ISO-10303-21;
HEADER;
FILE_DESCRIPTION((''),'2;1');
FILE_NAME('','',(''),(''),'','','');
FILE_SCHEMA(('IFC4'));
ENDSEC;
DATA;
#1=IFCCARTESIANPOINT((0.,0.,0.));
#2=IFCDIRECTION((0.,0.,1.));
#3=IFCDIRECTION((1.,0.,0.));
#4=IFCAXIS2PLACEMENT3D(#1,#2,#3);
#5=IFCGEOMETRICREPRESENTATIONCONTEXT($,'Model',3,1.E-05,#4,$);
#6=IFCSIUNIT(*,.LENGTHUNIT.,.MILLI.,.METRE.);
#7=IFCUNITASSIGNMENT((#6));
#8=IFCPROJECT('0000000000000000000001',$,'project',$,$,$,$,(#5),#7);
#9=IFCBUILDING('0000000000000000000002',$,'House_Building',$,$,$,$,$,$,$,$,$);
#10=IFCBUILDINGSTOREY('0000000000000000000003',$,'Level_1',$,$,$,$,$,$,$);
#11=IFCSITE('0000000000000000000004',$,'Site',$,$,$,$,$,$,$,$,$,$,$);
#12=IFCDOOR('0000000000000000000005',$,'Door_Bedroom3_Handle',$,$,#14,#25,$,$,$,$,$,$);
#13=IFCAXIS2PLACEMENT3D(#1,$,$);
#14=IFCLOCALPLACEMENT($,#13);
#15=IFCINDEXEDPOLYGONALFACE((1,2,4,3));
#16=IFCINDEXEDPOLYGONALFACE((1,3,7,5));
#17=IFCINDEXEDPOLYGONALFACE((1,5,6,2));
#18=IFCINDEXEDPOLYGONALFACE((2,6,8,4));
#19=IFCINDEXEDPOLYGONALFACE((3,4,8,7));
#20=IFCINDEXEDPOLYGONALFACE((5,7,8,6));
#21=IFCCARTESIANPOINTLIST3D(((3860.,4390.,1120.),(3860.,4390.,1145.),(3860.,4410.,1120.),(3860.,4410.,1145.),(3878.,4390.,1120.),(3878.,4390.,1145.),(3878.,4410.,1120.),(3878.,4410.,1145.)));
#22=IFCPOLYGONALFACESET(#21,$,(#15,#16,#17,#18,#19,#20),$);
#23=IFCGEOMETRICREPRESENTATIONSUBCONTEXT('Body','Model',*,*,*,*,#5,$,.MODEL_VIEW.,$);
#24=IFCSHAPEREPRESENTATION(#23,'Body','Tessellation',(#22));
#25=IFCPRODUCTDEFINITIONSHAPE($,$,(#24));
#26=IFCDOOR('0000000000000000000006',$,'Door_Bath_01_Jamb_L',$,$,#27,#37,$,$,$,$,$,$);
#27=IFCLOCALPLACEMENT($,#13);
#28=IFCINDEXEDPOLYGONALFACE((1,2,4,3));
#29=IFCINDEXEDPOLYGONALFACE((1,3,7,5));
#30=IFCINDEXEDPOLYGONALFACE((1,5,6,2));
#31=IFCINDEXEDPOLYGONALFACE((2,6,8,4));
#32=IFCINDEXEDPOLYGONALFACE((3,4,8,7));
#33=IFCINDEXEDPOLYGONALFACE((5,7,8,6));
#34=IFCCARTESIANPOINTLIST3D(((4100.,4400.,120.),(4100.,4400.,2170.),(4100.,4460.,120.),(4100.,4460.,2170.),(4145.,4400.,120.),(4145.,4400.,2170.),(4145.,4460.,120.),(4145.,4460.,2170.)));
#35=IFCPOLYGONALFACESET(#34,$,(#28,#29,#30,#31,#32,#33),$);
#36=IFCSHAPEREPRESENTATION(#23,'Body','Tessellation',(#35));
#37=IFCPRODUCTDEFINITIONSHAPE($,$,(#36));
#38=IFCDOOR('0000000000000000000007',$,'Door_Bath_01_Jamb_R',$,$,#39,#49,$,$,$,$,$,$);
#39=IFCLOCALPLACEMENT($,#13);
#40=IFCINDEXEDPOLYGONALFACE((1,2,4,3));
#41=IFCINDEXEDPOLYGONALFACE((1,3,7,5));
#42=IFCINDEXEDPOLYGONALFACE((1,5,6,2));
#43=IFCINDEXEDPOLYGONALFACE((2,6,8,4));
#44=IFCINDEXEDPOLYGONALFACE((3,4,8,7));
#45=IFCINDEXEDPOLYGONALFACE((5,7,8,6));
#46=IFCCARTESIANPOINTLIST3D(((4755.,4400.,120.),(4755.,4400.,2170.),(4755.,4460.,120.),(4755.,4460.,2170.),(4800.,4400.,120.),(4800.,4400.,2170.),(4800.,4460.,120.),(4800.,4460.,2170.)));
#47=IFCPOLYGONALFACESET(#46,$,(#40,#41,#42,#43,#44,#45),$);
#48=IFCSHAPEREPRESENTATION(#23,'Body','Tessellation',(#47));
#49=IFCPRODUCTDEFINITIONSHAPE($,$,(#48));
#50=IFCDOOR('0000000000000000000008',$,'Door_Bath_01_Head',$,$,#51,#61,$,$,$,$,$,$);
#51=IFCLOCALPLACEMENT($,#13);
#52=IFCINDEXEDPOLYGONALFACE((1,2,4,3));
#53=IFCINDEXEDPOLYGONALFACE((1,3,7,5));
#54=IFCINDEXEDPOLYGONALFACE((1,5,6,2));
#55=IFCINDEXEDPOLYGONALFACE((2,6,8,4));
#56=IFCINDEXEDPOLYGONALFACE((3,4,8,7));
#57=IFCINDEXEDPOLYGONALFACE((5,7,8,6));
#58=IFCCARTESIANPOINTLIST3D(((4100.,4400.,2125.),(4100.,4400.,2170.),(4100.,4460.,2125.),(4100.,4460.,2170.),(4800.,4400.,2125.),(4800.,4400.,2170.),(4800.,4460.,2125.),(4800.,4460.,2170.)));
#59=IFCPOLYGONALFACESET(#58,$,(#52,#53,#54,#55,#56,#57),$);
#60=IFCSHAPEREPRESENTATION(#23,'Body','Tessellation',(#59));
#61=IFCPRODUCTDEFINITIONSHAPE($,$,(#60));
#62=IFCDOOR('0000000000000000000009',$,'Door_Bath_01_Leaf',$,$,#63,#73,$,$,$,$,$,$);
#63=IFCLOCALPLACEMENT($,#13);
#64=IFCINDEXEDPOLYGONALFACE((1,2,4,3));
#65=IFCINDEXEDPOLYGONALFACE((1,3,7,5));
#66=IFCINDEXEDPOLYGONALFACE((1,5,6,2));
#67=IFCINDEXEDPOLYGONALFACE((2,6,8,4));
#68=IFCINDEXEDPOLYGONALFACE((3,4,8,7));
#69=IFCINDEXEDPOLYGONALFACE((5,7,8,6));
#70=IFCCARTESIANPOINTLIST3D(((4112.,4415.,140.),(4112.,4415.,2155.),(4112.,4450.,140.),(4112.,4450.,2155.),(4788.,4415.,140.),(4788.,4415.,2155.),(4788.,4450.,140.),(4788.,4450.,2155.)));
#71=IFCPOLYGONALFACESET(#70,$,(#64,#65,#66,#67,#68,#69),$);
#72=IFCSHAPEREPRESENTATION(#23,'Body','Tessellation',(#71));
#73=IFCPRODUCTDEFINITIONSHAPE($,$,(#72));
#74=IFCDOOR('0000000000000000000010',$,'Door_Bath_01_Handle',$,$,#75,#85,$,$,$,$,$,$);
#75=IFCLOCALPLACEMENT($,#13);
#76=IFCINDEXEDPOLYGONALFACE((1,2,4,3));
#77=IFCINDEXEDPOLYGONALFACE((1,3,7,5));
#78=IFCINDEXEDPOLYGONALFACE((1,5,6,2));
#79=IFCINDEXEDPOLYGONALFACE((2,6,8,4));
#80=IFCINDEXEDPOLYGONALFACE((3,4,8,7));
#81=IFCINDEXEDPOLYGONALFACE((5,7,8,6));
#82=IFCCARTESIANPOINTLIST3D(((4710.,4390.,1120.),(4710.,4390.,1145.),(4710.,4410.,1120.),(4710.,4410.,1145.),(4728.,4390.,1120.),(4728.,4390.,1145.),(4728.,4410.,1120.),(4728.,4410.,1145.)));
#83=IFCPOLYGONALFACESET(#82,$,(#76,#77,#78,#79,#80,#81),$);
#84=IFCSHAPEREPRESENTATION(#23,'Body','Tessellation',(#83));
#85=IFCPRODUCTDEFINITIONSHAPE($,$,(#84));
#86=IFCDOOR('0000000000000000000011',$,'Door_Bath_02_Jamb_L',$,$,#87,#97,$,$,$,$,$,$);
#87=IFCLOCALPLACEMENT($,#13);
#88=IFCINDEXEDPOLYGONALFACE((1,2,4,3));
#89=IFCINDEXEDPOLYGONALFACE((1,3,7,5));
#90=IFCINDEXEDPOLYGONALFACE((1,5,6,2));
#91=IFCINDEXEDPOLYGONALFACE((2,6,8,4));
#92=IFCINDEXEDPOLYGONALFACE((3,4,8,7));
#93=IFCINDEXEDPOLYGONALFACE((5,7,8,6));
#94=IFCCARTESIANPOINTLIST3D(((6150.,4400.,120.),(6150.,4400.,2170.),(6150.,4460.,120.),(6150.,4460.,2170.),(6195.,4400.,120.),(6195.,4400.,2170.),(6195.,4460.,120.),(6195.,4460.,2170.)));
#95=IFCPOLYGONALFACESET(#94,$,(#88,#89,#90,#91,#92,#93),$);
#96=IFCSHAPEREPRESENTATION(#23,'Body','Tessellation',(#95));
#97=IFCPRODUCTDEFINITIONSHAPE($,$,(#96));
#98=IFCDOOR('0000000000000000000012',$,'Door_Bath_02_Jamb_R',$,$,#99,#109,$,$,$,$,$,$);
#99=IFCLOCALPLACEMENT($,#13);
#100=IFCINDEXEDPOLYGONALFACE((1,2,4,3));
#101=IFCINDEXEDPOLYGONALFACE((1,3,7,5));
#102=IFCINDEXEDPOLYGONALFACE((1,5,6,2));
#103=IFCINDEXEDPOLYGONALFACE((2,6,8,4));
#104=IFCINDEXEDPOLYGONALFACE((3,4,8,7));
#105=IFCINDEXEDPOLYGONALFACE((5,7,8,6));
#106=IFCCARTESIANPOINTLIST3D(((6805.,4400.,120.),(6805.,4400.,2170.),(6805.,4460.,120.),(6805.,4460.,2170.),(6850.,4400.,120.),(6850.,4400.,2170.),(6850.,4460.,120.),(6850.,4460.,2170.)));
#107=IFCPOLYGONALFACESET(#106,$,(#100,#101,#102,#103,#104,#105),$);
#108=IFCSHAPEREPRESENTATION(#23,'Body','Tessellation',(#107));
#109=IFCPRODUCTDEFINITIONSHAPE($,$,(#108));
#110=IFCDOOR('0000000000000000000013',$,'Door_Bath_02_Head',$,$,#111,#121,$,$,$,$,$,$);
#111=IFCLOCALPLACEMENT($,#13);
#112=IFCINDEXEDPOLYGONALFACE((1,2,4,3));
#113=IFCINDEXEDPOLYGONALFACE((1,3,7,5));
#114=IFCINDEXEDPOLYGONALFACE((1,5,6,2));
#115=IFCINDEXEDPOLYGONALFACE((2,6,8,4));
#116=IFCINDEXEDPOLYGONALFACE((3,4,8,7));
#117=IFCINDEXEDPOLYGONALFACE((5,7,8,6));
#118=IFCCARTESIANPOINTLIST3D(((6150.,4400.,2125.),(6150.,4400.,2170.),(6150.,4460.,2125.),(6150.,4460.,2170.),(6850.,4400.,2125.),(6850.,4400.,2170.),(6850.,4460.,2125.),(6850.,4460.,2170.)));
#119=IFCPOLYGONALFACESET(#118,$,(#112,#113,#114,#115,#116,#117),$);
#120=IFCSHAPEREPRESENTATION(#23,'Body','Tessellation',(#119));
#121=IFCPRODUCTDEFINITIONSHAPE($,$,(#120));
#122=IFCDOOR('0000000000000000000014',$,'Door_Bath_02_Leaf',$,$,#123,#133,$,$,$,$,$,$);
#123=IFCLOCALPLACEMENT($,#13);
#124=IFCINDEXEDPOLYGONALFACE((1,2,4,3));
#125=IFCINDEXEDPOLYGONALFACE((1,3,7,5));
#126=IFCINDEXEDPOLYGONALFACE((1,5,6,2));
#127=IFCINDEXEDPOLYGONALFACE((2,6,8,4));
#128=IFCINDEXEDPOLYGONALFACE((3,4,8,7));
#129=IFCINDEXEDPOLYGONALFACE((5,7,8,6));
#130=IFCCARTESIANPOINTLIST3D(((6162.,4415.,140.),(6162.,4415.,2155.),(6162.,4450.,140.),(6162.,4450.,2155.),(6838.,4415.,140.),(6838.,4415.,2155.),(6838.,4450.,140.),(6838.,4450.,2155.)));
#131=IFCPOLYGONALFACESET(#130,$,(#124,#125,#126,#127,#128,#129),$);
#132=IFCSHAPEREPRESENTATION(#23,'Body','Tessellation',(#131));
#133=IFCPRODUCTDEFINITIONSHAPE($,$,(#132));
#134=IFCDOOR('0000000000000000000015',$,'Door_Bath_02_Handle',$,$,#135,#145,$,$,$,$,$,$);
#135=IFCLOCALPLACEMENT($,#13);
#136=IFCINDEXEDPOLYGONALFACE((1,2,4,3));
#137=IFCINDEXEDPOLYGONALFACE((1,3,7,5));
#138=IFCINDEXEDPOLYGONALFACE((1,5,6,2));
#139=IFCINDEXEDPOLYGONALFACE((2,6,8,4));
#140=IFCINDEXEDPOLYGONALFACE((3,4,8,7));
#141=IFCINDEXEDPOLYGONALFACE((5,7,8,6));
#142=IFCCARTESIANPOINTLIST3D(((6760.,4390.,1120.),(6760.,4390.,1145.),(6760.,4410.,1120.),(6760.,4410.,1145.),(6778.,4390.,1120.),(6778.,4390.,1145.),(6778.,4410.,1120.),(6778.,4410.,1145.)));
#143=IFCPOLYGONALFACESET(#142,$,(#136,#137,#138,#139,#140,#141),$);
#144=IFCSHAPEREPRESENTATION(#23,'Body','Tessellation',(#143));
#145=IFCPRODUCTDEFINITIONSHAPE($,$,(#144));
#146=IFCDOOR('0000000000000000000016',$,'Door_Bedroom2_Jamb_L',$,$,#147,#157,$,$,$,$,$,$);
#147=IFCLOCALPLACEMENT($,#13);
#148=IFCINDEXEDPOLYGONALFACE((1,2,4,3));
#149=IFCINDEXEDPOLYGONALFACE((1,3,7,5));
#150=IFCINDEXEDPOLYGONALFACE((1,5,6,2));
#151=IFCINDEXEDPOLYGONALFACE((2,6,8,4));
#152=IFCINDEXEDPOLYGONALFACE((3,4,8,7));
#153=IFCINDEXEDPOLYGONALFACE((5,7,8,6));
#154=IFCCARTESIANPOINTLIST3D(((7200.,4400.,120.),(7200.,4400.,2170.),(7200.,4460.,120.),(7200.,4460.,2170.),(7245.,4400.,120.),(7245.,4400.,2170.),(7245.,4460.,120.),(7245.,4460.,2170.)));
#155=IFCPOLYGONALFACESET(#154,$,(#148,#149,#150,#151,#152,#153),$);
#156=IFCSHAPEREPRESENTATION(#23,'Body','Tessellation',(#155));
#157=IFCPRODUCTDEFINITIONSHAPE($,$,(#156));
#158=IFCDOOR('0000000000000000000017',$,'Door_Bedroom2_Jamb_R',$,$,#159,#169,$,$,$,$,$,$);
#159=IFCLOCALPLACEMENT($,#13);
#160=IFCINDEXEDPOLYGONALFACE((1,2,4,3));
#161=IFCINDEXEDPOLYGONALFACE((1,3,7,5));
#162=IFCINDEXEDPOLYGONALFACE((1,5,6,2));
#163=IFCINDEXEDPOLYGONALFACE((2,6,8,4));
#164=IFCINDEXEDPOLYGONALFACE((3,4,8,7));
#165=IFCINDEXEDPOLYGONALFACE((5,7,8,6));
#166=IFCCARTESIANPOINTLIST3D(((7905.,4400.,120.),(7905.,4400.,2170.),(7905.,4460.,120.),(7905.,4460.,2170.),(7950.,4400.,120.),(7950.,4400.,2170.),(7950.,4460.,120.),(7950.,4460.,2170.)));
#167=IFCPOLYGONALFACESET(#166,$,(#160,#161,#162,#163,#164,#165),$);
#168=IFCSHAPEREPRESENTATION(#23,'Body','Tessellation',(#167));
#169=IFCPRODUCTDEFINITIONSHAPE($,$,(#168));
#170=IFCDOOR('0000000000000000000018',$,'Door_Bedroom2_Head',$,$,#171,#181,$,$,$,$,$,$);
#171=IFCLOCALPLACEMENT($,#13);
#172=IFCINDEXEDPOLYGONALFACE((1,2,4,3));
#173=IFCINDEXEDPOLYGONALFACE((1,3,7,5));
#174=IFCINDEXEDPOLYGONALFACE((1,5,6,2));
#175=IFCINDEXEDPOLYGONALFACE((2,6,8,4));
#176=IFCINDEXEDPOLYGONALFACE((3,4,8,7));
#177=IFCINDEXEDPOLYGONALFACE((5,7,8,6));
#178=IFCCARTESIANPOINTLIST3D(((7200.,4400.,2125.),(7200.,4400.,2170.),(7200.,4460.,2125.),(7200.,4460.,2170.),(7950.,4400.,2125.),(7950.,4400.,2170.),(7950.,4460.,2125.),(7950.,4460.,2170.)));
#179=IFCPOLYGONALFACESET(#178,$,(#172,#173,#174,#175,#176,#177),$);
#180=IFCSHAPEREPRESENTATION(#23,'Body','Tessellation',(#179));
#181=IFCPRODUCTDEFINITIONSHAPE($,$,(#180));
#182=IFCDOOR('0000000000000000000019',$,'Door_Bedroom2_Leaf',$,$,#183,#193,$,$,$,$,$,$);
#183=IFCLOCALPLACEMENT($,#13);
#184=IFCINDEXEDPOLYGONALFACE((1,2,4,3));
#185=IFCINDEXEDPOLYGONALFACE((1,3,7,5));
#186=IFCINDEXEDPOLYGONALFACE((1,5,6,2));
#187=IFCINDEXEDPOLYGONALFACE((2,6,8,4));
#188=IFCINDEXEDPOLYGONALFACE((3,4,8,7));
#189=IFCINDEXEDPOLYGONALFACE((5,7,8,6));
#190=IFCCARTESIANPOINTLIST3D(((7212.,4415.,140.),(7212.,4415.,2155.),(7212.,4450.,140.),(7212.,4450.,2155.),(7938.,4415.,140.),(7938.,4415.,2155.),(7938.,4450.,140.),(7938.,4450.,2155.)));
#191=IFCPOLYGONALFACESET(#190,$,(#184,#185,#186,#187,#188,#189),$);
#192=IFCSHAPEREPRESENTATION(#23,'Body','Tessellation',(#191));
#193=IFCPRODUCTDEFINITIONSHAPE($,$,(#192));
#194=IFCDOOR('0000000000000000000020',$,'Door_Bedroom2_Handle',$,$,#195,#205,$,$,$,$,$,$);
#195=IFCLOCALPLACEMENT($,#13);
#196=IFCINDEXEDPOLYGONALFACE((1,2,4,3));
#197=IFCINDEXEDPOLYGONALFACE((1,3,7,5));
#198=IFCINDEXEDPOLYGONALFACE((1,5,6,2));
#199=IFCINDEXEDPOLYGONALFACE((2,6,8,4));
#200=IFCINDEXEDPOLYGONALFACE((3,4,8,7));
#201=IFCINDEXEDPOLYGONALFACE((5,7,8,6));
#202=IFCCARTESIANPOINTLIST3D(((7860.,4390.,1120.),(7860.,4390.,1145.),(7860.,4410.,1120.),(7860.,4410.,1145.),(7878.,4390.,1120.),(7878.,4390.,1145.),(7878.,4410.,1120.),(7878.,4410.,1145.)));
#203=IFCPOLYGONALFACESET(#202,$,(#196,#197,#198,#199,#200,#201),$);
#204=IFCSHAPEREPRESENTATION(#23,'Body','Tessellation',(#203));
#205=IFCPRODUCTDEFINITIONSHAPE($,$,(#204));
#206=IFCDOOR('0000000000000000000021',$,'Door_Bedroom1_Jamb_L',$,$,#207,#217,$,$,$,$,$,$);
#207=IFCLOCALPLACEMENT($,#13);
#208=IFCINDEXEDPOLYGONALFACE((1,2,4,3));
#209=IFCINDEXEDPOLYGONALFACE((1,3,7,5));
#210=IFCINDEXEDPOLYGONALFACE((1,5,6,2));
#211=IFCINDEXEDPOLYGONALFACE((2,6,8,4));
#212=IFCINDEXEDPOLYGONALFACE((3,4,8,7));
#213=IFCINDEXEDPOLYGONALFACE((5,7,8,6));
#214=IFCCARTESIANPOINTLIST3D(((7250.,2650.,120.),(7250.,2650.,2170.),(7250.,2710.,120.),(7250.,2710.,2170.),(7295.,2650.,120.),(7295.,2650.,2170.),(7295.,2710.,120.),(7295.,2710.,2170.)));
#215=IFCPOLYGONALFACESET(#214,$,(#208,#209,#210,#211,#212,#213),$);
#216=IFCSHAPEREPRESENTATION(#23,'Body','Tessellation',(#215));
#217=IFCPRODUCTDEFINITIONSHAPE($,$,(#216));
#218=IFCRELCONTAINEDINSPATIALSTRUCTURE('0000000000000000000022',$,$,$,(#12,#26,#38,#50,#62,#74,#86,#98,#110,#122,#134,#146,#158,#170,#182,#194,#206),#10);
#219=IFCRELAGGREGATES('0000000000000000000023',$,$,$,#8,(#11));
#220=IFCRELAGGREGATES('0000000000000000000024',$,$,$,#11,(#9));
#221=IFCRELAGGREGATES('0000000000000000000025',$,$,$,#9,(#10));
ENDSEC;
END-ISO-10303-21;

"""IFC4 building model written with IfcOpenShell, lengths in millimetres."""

from ifc_helpers import new_model, si_unit, frame, origin_with_axes, context, subcontext, project, spatial, polyline, outline, extrude, element, save


model = new_model("IFC4")

# Units and contexts
model_context = context("Model", 3, precision=1e-05, world=origin_with_axes())
body_context = subcontext(model_context, "Body", "Model", "MODEL_VIEW")
ifc_project = project(units=[si_unit("LENGTHUNIT", "METRE", prefix="MILLI")], contexts=[model_context])

# Site, building, storey
site = spatial("IfcSite", under=ifc_project, Name="Site")
building = spatial("IfcBuilding", under=site, Name="House_Building")
storey = spatial("IfcBuildingStorey", under=building, Name="Level_1")

# Doors
element("IfcDoor", 1, inside=storey, Name="Door_Bedroom3_Handle", context=body_context, shape_type="SweptSolid", body=[
    extrude(outline(polyline([(3860.0, 4390.0), (3878.0, 4390.0), (3878.0, 4410.0), (3860.0, 4410.0), (3860.0, 4390.0)])), frame((0.0, 0.0, 1120.0), z_axis=(0.0, 0.0, 1.0), x_axis=(1.0, 0.0, 0.0)), (0.0, 0.0, 1.0), 25.0),
])
element("IfcDoor", 2, inside=storey, Name="Door_Bath_01_Jamb_L", context=body_context, shape_type="SweptSolid", body=[
    extrude(outline(polyline([(4100.0, 4400.0), (4145.0, 4400.0), (4145.0, 4460.0), (4100.0, 4460.0), (4100.0, 4400.0)])), frame((0.0, 0.0, 120.0), z_axis=(0.0, 0.0, 1.0), x_axis=(1.0, 0.0, 0.0)), (0.0, 0.0, 1.0), 2050.0),
])
element("IfcDoor", 3, inside=storey, Name="Door_Bath_01_Jamb_R", context=body_context, shape_type="SweptSolid", body=[
    extrude(outline(polyline([(4755.0, 4400.0), (4800.0, 4400.0), (4800.0, 4460.0), (4755.0, 4460.0), (4755.0, 4400.0)])), frame((0.0, 0.0, 120.0), z_axis=(0.0, 0.0, 1.0), x_axis=(1.0, 0.0, 0.0)), (0.0, 0.0, 1.0), 2050.0),
])
element("IfcDoor", 4, inside=storey, Name="Door_Bath_01_Head", context=body_context, shape_type="SweptSolid", body=[
    extrude(outline(polyline([(4100.0, 4400.0), (4800.0, 4400.0), (4800.0, 4460.0), (4100.0, 4460.0), (4100.0, 4400.0)])), frame((0.0, 0.0, 2125.0), z_axis=(0.0, 0.0, 1.0), x_axis=(1.0, 0.0, 0.0)), (0.0, 0.0, 1.0), 45.0),
])
element("IfcDoor", 5, inside=storey, Name="Door_Bath_01_Leaf", context=body_context, shape_type="SweptSolid", body=[
    extrude(outline(polyline([(4112.0, 4415.0), (4788.0, 4415.0), (4788.0, 4450.0), (4112.0, 4450.0), (4112.0, 4415.0)])), frame((0.0, 0.0, 140.0), z_axis=(0.0, 0.0, 1.0), x_axis=(1.0, 0.0, 0.0)), (0.0, 0.0, 1.0), 2015.0),
])
element("IfcDoor", 6, inside=storey, Name="Door_Bath_01_Handle", context=body_context, shape_type="SweptSolid", body=[
    extrude(outline(polyline([(4710.0, 4390.0), (4728.0, 4390.0), (4728.0, 4410.0), (4710.0, 4410.0), (4710.0, 4390.0)])), frame((0.0, 0.0, 1120.0), z_axis=(0.0, 0.0, 1.0), x_axis=(1.0, 0.0, 0.0)), (0.0, 0.0, 1.0), 25.0),
])
element("IfcDoor", 7, inside=storey, Name="Door_Bath_02_Jamb_L", context=body_context, shape_type="SweptSolid", body=[
    extrude(outline(polyline([(6150.0, 4400.0), (6195.0, 4400.0), (6195.0, 4460.0), (6150.0, 4460.0), (6150.0, 4400.0)])), frame((0.0, 0.0, 120.0), z_axis=(0.0, 0.0, 1.0), x_axis=(1.0, 0.0, 0.0)), (0.0, 0.0, 1.0), 2050.0),
])
element("IfcDoor", 8, inside=storey, Name="Door_Bath_02_Jamb_R", context=body_context, shape_type="SweptSolid", body=[
    extrude(outline(polyline([(6805.0, 4400.0), (6850.0, 4400.0), (6850.0, 4460.0), (6805.0, 4460.0), (6805.0, 4400.0)])), frame((0.0, 0.0, 120.0), z_axis=(0.0, 0.0, 1.0), x_axis=(1.0, 0.0, 0.0)), (0.0, 0.0, 1.0), 2050.0),
])
element("IfcDoor", 9, inside=storey, Name="Door_Bath_02_Head", context=body_context, shape_type="SweptSolid", body=[
    extrude(outline(polyline([(6150.0, 4400.0), (6850.0, 4400.0), (6850.0, 4460.0), (6150.0, 4460.0), (6150.0, 4400.0)])), frame((0.0, 0.0, 2125.0), z_axis=(0.0, 0.0, 1.0), x_axis=(1.0, 0.0, 0.0)), (0.0, 0.0, 1.0), 45.0),
])
element("IfcDoor", 10, inside=storey, Name="Door_Bath_02_Leaf", context=body_context, shape_type="SweptSolid", body=[
    extrude(outline(polyline([(6162.0, 4415.0), (6838.0, 4415.0), (6838.0, 4450.0), (6162.0, 4450.0), (6162.0, 4415.0)])), frame((0.0, 0.0, 140.0), z_axis=(0.0, 0.0, 1.0), x_axis=(1.0, 0.0, 0.0)), (0.0, 0.0, 1.0), 2015.0),
])
element("IfcDoor", 11, inside=storey, Name="Door_Bath_02_Handle", context=body_context, shape_type="SweptSolid", body=[
    extrude(outline(polyline([(6760.0, 4390.0), (6778.0, 4390.0), (6778.0, 4410.0), (6760.0, 4410.0), (6760.0, 4390.0)])), frame((0.0, 0.0, 1120.0), z_axis=(0.0, 0.0, 1.0), x_axis=(1.0, 0.0, 0.0)), (0.0, 0.0, 1.0), 25.0),
])
element("IfcDoor", 12, inside=storey, Name="Door_Bedroom2_Jamb_L", context=body_context, shape_type="SweptSolid", body=[
    extrude(outline(polyline([(7200.0, 4400.0), (7245.0, 4400.0), (7245.0, 4460.0), (7200.0, 4460.0), (7200.0, 4400.0)])), frame((0.0, 0.0, 120.0), z_axis=(0.0, 0.0, 1.0), x_axis=(1.0, 0.0, 0.0)), (0.0, 0.0, 1.0), 2050.0),
])
element("IfcDoor", 13, inside=storey, Name="Door_Bedroom2_Jamb_R", context=body_context, shape_type="SweptSolid", body=[
    extrude(outline(polyline([(7905.0, 4400.0), (7950.0, 4400.0), (7950.0, 4460.0), (7905.0, 4460.0), (7905.0, 4400.0)])), frame((0.0, 0.0, 120.0), z_axis=(0.0, 0.0, 1.0), x_axis=(1.0, 0.0, 0.0)), (0.0, 0.0, 1.0), 2050.0),
])
element("IfcDoor", 14, inside=storey, Name="Door_Bedroom2_Head", context=body_context, shape_type="SweptSolid", body=[
    extrude(outline(polyline([(7200.0, 4400.0), (7950.0, 4400.0), (7950.0, 4460.0), (7200.0, 4460.0), (7200.0, 4400.0)])), frame((0.0, 0.0, 2125.0), z_axis=(0.0, 0.0, 1.0), x_axis=(1.0, 0.0, 0.0)), (0.0, 0.0, 1.0), 45.0),
])
element("IfcDoor", 15, inside=storey, Name="Door_Bedroom2_Leaf", context=body_context, shape_type="SweptSolid", body=[
    extrude(outline(polyline([(7212.0, 4415.0), (7938.0, 4415.0), (7938.0, 4450.0), (7212.0, 4450.0), (7212.0, 4415.0)])), frame((0.0, 0.0, 140.0), z_axis=(0.0, 0.0, 1.0), x_axis=(1.0, 0.0, 0.0)), (0.0, 0.0, 1.0), 2015.0),
])
element("IfcDoor", 16, inside=storey, Name="Door_Bedroom2_Handle", context=body_context, shape_type="SweptSolid", body=[
    extrude(outline(polyline([(7860.0, 4390.0), (7878.0, 4390.0), (7878.0, 4410.0), (7860.0, 4410.0), (7860.0, 4390.0)])), frame((0.0, 0.0, 1120.0), z_axis=(0.0, 0.0, 1.0), x_axis=(1.0, 0.0, 0.0)), (0.0, 0.0, 1.0), 25.0),
])
element("IfcDoor", 17, inside=storey, Name="Door_Bedroom1_Jamb_L", context=body_context, shape_type="SweptSolid", body=[
    extrude(outline(polyline([(7250.0, 2650.0), (7295.0, 2650.0), (7295.0, 2710.0), (7250.0, 2710.0), (7250.0, 2650.0)])), frame((0.0, 0.0, 120.0), z_axis=(0.0, 0.0, 1.0), x_axis=(1.0, 0.0, 0.0)), (0.0, 0.0, 1.0), 2050.0),
])

save(model, "model.ifc")
